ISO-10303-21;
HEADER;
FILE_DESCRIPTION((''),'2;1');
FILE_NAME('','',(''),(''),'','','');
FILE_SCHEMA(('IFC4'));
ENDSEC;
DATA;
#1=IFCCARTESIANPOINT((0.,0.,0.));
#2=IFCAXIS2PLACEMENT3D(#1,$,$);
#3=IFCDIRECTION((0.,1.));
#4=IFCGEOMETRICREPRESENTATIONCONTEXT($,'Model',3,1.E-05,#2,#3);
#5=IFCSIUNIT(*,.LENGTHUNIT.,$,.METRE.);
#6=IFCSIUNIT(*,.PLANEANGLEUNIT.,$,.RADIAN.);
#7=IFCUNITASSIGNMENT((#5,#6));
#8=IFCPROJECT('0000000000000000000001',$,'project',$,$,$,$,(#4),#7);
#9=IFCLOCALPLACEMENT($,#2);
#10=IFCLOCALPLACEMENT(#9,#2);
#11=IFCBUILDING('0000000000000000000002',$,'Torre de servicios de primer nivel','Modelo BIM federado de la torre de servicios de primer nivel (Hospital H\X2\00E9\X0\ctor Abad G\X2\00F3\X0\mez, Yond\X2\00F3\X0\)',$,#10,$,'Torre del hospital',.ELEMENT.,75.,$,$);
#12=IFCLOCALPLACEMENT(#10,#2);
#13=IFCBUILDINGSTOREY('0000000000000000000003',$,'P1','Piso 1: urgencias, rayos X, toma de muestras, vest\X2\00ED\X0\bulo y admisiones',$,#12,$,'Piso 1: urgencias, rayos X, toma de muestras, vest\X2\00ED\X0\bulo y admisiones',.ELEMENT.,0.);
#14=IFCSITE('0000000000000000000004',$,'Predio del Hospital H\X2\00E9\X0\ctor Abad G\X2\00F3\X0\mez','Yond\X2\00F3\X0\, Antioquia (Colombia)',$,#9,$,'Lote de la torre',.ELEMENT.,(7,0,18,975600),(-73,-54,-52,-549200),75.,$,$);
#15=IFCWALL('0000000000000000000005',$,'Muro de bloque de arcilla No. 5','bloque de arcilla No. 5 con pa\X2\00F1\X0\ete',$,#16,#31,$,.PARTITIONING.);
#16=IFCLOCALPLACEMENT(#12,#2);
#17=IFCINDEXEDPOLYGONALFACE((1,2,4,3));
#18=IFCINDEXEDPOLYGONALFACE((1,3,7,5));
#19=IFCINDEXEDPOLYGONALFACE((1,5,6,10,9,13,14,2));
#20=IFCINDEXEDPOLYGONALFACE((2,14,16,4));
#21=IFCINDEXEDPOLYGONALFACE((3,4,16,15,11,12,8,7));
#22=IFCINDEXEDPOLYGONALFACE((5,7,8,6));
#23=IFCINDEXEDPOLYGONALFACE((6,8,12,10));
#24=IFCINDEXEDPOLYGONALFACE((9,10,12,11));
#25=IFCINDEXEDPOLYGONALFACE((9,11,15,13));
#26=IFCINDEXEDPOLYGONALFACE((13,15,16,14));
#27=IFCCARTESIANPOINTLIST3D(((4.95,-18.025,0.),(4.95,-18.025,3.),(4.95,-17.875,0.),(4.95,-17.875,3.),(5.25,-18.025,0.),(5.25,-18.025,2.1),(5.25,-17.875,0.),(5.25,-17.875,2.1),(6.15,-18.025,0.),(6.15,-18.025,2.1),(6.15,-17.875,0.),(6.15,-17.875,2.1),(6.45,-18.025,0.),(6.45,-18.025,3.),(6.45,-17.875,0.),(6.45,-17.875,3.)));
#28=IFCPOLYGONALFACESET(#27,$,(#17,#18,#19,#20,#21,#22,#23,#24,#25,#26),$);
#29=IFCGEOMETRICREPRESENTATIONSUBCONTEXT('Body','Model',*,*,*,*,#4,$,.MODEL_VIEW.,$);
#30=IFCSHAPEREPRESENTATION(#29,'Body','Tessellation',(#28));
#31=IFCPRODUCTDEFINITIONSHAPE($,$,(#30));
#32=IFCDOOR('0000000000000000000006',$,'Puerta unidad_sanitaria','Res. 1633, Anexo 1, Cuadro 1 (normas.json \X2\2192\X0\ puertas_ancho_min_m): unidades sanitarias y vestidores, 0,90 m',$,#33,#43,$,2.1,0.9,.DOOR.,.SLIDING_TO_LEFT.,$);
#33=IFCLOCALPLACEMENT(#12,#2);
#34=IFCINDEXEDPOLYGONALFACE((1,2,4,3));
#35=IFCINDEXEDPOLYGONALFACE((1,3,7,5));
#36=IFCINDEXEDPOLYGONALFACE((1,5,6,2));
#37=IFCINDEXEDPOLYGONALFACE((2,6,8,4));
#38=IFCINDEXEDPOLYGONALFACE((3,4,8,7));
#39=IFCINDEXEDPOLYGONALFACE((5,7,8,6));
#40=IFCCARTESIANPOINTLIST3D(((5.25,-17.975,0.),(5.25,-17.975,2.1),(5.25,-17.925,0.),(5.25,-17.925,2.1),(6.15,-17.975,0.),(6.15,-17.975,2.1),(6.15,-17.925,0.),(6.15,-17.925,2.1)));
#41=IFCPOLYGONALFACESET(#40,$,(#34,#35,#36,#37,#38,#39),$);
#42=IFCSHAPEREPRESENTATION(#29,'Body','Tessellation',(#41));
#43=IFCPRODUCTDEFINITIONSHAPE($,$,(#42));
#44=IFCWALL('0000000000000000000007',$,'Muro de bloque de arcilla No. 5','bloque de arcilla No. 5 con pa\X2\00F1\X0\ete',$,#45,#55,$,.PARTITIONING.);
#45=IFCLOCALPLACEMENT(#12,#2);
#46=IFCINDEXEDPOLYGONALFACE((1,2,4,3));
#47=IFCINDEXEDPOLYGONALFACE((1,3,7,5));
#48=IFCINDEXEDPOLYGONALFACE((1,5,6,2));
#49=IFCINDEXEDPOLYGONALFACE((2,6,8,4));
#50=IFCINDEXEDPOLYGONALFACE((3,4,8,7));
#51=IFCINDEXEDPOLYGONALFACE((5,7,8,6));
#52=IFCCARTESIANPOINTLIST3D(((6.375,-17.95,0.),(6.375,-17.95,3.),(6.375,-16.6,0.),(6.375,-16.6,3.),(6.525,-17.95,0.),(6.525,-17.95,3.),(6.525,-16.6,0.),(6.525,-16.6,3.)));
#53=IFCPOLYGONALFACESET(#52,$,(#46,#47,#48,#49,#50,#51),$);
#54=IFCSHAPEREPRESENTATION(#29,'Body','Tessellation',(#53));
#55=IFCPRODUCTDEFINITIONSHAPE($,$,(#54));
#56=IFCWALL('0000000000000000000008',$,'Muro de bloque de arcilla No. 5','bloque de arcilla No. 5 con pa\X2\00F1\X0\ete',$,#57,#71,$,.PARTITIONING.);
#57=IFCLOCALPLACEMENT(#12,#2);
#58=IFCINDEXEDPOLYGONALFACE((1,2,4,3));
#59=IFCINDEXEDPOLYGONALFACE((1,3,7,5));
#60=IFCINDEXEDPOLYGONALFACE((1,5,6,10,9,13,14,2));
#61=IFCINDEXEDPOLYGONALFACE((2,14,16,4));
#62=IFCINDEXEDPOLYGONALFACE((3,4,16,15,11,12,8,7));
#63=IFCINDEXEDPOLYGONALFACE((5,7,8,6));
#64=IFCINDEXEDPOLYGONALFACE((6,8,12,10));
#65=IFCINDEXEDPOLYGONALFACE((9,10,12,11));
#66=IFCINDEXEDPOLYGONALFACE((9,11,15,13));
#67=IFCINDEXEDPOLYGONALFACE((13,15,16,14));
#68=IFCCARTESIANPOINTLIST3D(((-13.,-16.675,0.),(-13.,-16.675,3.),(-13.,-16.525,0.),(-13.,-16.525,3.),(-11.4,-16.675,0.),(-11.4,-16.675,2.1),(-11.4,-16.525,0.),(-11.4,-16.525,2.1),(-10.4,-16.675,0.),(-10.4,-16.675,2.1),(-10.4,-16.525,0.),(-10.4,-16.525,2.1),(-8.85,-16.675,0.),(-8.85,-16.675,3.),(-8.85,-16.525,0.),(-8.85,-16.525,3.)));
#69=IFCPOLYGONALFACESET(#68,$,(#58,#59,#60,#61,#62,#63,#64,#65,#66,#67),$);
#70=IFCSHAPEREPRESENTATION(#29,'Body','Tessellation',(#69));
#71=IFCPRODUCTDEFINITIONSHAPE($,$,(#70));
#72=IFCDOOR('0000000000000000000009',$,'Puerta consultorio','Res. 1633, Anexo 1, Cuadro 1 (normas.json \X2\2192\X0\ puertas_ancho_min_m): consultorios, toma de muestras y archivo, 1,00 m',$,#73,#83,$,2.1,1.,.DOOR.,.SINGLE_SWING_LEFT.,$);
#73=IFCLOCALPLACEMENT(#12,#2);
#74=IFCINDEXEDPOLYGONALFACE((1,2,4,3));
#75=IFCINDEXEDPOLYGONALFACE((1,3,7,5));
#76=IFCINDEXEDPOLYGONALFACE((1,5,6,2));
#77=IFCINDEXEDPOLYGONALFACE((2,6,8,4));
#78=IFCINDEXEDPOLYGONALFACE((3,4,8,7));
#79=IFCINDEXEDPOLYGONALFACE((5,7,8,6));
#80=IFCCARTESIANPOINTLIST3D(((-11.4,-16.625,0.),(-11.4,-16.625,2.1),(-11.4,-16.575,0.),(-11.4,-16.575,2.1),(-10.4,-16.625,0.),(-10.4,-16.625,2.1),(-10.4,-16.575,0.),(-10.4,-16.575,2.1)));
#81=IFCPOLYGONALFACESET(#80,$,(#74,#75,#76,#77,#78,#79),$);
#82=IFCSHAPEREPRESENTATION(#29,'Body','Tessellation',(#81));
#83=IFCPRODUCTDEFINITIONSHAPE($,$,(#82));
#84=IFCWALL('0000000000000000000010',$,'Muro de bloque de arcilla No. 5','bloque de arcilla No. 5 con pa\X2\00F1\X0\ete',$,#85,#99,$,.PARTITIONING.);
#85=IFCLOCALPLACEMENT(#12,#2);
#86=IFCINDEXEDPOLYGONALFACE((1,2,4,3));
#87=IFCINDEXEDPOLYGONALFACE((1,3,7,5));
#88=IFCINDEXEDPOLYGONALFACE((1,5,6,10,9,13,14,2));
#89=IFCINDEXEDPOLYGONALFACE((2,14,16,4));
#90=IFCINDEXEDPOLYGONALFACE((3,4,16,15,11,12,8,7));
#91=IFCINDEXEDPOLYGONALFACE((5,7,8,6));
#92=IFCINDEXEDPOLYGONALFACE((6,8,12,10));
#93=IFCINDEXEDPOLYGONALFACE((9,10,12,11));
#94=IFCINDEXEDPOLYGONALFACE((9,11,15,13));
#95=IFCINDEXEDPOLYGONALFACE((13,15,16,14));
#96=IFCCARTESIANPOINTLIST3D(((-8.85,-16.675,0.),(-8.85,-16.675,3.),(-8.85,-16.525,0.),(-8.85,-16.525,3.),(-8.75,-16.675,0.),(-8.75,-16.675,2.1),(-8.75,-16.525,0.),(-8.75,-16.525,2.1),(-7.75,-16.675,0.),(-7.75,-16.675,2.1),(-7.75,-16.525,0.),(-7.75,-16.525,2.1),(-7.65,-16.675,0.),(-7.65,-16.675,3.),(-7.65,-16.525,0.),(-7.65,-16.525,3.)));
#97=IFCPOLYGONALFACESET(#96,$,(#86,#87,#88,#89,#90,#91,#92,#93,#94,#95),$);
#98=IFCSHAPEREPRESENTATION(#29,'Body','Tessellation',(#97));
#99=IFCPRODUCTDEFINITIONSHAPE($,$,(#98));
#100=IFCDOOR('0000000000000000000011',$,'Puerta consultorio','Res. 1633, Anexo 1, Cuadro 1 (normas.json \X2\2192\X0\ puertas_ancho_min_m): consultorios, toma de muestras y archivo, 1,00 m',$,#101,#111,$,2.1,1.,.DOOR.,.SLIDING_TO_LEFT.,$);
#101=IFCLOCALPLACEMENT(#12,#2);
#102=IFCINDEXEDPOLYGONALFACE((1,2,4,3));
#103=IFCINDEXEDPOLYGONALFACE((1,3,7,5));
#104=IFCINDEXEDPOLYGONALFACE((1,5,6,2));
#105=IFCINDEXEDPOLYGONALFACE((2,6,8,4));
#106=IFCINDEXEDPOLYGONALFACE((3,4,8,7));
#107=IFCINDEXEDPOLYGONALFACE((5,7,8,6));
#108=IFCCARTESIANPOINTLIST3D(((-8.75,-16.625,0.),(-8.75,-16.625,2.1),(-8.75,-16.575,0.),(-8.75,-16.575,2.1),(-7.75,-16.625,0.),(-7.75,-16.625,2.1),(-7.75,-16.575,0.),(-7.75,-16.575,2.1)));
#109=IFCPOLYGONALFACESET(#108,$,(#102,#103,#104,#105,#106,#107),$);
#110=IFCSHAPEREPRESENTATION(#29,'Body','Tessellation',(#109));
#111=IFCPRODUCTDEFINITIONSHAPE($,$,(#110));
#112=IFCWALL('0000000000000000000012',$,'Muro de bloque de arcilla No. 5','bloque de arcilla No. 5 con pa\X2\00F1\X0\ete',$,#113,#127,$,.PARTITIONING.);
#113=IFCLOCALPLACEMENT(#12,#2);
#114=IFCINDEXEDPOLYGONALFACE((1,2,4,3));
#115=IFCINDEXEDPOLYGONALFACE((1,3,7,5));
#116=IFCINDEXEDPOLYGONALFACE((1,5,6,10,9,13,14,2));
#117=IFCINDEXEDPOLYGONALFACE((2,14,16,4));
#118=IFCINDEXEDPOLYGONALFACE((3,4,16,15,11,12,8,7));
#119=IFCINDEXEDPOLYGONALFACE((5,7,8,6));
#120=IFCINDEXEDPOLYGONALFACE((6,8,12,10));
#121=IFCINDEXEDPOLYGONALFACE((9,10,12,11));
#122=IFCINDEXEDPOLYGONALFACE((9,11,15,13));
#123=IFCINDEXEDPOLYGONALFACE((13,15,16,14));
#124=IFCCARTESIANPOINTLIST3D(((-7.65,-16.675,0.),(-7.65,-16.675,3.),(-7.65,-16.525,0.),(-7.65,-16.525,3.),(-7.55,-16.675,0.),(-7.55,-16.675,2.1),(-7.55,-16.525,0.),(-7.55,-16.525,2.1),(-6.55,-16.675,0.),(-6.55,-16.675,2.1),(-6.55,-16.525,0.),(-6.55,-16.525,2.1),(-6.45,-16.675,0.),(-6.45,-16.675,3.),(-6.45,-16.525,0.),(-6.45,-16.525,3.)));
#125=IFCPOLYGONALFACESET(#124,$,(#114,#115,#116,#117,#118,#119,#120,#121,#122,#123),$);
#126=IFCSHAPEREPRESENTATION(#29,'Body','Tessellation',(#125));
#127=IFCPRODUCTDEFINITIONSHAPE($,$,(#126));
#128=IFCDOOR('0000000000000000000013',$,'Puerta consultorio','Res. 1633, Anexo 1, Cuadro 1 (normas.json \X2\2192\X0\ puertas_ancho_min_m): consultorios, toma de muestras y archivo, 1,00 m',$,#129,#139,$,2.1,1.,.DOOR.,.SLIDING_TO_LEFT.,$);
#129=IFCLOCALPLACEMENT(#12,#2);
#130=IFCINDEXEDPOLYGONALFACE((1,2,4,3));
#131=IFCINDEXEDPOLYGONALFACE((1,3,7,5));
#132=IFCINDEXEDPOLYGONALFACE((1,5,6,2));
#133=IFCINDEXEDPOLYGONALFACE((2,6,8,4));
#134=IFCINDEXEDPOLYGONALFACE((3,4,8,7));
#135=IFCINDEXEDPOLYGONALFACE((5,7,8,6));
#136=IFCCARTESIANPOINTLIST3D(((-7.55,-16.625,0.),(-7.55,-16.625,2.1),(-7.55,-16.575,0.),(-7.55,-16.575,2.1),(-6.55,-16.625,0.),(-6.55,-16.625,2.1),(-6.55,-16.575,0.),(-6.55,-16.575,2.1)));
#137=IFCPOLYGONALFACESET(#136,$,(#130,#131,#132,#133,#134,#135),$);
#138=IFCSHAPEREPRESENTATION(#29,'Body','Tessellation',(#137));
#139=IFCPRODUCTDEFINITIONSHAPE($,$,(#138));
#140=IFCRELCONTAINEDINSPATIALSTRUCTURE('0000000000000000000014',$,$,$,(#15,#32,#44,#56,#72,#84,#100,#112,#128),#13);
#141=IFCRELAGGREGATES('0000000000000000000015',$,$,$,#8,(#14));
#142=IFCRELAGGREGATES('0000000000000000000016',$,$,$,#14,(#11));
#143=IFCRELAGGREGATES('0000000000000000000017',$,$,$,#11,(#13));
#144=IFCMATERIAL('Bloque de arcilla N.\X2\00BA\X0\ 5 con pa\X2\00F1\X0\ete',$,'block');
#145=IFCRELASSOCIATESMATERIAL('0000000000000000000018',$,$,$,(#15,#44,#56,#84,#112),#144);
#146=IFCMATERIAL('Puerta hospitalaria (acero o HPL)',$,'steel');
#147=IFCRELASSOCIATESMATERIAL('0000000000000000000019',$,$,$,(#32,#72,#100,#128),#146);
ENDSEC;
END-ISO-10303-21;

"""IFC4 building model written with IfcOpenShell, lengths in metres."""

from ifc_helpers import new_model, si_unit, direction, frame, origin, place, context, subcontext, project, spatial, rectangle, extrude, material, element, fill, save


model = new_model("IFC4")

# Units and contexts
model_context = context("Model", 3, precision=1e-05, world=origin(), true_north=direction((0.0, 1.0)))
body_context = subcontext(model_context, "Body", "Model", "MODEL_VIEW")
ifc_project = project(units=[si_unit("LENGTHUNIT", "METRE"), si_unit("PLANEANGLEUNIT", "RADIAN")], contexts=[model_context])

# Site, building, storey
site_placement = place(None, origin())
site = spatial("IfcSite", under=ifc_project, at=site_placement, Name="Predio del Hospital Héctor Abad Gómez", Description="Yondó, Antioquia (Colombia)", LongName="Lote de la torre", CompositionType="ELEMENT", RefLatitude=(7, 0, 18, 975600), RefLongitude=(-73, -54, -52, -549200), RefElevation=75.0)
building_placement = place(site_placement, origin())
building = spatial("IfcBuilding", under=site, at=building_placement, Name="Torre de servicios de primer nivel", Description="Modelo BIM federado de la torre de servicios de primer nivel (Hospital Héctor Abad Gómez, Yondó)", LongName="Torre del hospital", CompositionType="ELEMENT", ElevationOfRefHeight=75.0)
placement = place(building_placement, origin())
storey = spatial("IfcBuildingStorey", under=building, at=placement, Name="P1", Description="Piso 1: urgencias, rayos X, toma de muestras, vestíbulo y admisiones", LongName="Piso 1: urgencias, rayos X, toma de muestras, vestíbulo y admisiones", CompositionType="ELEMENT", Elevation=0.0)

# Shared definitions
ifc_material_1 = material(Name="Bloque de arcilla N.º 5 con pañete", Category="block")

# Shared definitions
ifc_material_2 = material(Name="Puerta hospitalaria (acero o HPL)", Category="steel")

# Wall, opening, door
wall_1 = element("IfcWall", 1, at=placement, inside=storey, material=ifc_material_1, Name="Muro de bloque de arcilla No. 5", Description="bloque de arcilla No. 5 con pañete", PredefinedType="PARTITIONING", context=body_context, shape_type="SweptSolid", body=[
    extrude(rectangle(XDim=1.5, YDim=0.15), frame((5.7, -17.95, 0.0)), (0.0, 0.0, 1.0), 3.0),
])
opening_1 = element("IfcOpeningElement", 2, at=placement, cuts=wall_1, PredefinedType="OPENING", context=body_context, shape_type="SweptSolid", body=[
    extrude(rectangle(XDim=0.9, YDim=0.25), frame((5.7, -17.95, 0.0)), (0.0, 0.0, 1.0), 2.1),
])
door_1 = element("IfcDoor", 3, at=placement, inside=storey, material=ifc_material_2, Name="Puerta unidad_sanitaria", Description="Res. 1633, Anexo 1, Cuadro 1 (normas.json → puertas_ancho_min_m): unidades sanitarias y vestidores, 0,90 m", OperationType="SLIDING_TO_LEFT", OverallHeight=2.1, OverallWidth=0.9, PredefinedType="DOOR", context=body_context, shape_type="SweptSolid", body=[
    extrude(rectangle(XDim=0.9, YDim=0.05), frame((5.7, -17.95, 0.0)), (0.0, 0.0, 1.0), 2.1),
])
fill(opening_1, door_1)

# Wall
element("IfcWall", 4, at=placement, inside=storey, material=ifc_material_1, Name="Muro de bloque de arcilla No. 5", Description="bloque de arcilla No. 5 con pañete", PredefinedType="PARTITIONING", context=body_context, shape_type="SweptSolid", body=[
    extrude(rectangle(XDim=0.15, YDim=1.35), frame((6.45, -17.275, 0.0)), (0.0, 0.0, 1.0), 3.0),
])

# Walls, openings, doors
wall_2 = element("IfcWall", 5, at=placement, inside=storey, material=ifc_material_1, Name="Muro de bloque de arcilla No. 5", Description="bloque de arcilla No. 5 con pañete", PredefinedType="PARTITIONING", context=body_context, shape_type="SweptSolid", body=[
    extrude(rectangle(XDim=4.15, YDim=0.15), frame((-10.925, -16.6, 0.0)), (0.0, 0.0, 1.0), 3.0),
])
opening_2 = element("IfcOpeningElement", 6, at=placement, cuts=wall_2, PredefinedType="OPENING", context=body_context, shape_type="SweptSolid", body=[
    extrude(rectangle(XDim=1.0, YDim=0.25), frame((-10.9, -16.6, 0.0)), (0.0, 0.0, 1.0), 2.1),
])
door_2 = element("IfcDoor", 7, at=placement, inside=storey, material=ifc_material_2, Name="Puerta consultorio", Description="Res. 1633, Anexo 1, Cuadro 1 (normas.json → puertas_ancho_min_m): consultorios, toma de muestras y archivo, 1,00 m", OperationType="SINGLE_SWING_LEFT", OverallHeight=2.1, OverallWidth=1.0, PredefinedType="DOOR", context=body_context, shape_type="SweptSolid", body=[
    extrude(rectangle(XDim=1.0, YDim=0.05), frame((-10.9, -16.6, 0.0)), (0.0, 0.0, 1.0), 2.1),
])
fill(opening_2, door_2)
wall_3 = element("IfcWall", 8, at=placement, inside=storey, material=ifc_material_1, Name="Muro de bloque de arcilla No. 5", Description="bloque de arcilla No. 5 con pañete", PredefinedType="PARTITIONING", context=body_context, shape_type="SweptSolid", body=[
    extrude(rectangle(XDim=1.2, YDim=0.15), frame((-8.25, -16.6, 0.0)), (0.0, 0.0, 1.0), 3.0),
])
opening_3 = element("IfcOpeningElement", 9, at=placement, cuts=wall_3, PredefinedType="OPENING", context=body_context, shape_type="SweptSolid", body=[
    extrude(rectangle(XDim=1.0, YDim=0.25), frame((-8.25, -16.6, 0.0)), (0.0, 0.0, 1.0), 2.1),
])
door_3 = element("IfcDoor", 10, at=placement, inside=storey, material=ifc_material_2, Name="Puerta consultorio", Description="Res. 1633, Anexo 1, Cuadro 1 (normas.json → puertas_ancho_min_m): consultorios, toma de muestras y archivo, 1,00 m", OperationType="SLIDING_TO_LEFT", OverallHeight=2.1, OverallWidth=1.0, PredefinedType="DOOR", context=body_context, shape_type="SweptSolid", body=[
    extrude(rectangle(XDim=1.0, YDim=0.05), frame((-8.25, -16.6, 0.0)), (0.0, 0.0, 1.0), 2.1),
])
fill(opening_3, door_3)
wall_4 = element("IfcWall", 11, at=placement, inside=storey, material=ifc_material_1, Name="Muro de bloque de arcilla No. 5", Description="bloque de arcilla No. 5 con pañete", PredefinedType="PARTITIONING", context=body_context, shape_type="SweptSolid", body=[
    extrude(rectangle(XDim=1.2, YDim=0.15), frame((-7.05, -16.6, 0.0)), (0.0, 0.0, 1.0), 3.0),
])
opening_4 = element("IfcOpeningElement", 12, at=placement, cuts=wall_4, PredefinedType="OPENING", context=body_context, shape_type="SweptSolid", body=[
    extrude(rectangle(XDim=1.0, YDim=0.25), frame((-7.05, -16.6, 0.0)), (0.0, 0.0, 1.0), 2.1),
])
door_4 = element("IfcDoor", 13, at=placement, inside=storey, material=ifc_material_2, Name="Puerta consultorio", Description="Res. 1633, Anexo 1, Cuadro 1 (normas.json → puertas_ancho_min_m): consultorios, toma de muestras y archivo, 1,00 m", OperationType="SLIDING_TO_LEFT", OverallHeight=2.1, OverallWidth=1.0, PredefinedType="DOOR", context=body_context, shape_type="SweptSolid", body=[
    extrude(rectangle(XDim=1.0, YDim=0.05), frame((-7.05, -16.6, 0.0)), (0.0, 0.0, 1.0), 2.1),
])
fill(opening_4, door_4)

save(model, "model.ifc")
